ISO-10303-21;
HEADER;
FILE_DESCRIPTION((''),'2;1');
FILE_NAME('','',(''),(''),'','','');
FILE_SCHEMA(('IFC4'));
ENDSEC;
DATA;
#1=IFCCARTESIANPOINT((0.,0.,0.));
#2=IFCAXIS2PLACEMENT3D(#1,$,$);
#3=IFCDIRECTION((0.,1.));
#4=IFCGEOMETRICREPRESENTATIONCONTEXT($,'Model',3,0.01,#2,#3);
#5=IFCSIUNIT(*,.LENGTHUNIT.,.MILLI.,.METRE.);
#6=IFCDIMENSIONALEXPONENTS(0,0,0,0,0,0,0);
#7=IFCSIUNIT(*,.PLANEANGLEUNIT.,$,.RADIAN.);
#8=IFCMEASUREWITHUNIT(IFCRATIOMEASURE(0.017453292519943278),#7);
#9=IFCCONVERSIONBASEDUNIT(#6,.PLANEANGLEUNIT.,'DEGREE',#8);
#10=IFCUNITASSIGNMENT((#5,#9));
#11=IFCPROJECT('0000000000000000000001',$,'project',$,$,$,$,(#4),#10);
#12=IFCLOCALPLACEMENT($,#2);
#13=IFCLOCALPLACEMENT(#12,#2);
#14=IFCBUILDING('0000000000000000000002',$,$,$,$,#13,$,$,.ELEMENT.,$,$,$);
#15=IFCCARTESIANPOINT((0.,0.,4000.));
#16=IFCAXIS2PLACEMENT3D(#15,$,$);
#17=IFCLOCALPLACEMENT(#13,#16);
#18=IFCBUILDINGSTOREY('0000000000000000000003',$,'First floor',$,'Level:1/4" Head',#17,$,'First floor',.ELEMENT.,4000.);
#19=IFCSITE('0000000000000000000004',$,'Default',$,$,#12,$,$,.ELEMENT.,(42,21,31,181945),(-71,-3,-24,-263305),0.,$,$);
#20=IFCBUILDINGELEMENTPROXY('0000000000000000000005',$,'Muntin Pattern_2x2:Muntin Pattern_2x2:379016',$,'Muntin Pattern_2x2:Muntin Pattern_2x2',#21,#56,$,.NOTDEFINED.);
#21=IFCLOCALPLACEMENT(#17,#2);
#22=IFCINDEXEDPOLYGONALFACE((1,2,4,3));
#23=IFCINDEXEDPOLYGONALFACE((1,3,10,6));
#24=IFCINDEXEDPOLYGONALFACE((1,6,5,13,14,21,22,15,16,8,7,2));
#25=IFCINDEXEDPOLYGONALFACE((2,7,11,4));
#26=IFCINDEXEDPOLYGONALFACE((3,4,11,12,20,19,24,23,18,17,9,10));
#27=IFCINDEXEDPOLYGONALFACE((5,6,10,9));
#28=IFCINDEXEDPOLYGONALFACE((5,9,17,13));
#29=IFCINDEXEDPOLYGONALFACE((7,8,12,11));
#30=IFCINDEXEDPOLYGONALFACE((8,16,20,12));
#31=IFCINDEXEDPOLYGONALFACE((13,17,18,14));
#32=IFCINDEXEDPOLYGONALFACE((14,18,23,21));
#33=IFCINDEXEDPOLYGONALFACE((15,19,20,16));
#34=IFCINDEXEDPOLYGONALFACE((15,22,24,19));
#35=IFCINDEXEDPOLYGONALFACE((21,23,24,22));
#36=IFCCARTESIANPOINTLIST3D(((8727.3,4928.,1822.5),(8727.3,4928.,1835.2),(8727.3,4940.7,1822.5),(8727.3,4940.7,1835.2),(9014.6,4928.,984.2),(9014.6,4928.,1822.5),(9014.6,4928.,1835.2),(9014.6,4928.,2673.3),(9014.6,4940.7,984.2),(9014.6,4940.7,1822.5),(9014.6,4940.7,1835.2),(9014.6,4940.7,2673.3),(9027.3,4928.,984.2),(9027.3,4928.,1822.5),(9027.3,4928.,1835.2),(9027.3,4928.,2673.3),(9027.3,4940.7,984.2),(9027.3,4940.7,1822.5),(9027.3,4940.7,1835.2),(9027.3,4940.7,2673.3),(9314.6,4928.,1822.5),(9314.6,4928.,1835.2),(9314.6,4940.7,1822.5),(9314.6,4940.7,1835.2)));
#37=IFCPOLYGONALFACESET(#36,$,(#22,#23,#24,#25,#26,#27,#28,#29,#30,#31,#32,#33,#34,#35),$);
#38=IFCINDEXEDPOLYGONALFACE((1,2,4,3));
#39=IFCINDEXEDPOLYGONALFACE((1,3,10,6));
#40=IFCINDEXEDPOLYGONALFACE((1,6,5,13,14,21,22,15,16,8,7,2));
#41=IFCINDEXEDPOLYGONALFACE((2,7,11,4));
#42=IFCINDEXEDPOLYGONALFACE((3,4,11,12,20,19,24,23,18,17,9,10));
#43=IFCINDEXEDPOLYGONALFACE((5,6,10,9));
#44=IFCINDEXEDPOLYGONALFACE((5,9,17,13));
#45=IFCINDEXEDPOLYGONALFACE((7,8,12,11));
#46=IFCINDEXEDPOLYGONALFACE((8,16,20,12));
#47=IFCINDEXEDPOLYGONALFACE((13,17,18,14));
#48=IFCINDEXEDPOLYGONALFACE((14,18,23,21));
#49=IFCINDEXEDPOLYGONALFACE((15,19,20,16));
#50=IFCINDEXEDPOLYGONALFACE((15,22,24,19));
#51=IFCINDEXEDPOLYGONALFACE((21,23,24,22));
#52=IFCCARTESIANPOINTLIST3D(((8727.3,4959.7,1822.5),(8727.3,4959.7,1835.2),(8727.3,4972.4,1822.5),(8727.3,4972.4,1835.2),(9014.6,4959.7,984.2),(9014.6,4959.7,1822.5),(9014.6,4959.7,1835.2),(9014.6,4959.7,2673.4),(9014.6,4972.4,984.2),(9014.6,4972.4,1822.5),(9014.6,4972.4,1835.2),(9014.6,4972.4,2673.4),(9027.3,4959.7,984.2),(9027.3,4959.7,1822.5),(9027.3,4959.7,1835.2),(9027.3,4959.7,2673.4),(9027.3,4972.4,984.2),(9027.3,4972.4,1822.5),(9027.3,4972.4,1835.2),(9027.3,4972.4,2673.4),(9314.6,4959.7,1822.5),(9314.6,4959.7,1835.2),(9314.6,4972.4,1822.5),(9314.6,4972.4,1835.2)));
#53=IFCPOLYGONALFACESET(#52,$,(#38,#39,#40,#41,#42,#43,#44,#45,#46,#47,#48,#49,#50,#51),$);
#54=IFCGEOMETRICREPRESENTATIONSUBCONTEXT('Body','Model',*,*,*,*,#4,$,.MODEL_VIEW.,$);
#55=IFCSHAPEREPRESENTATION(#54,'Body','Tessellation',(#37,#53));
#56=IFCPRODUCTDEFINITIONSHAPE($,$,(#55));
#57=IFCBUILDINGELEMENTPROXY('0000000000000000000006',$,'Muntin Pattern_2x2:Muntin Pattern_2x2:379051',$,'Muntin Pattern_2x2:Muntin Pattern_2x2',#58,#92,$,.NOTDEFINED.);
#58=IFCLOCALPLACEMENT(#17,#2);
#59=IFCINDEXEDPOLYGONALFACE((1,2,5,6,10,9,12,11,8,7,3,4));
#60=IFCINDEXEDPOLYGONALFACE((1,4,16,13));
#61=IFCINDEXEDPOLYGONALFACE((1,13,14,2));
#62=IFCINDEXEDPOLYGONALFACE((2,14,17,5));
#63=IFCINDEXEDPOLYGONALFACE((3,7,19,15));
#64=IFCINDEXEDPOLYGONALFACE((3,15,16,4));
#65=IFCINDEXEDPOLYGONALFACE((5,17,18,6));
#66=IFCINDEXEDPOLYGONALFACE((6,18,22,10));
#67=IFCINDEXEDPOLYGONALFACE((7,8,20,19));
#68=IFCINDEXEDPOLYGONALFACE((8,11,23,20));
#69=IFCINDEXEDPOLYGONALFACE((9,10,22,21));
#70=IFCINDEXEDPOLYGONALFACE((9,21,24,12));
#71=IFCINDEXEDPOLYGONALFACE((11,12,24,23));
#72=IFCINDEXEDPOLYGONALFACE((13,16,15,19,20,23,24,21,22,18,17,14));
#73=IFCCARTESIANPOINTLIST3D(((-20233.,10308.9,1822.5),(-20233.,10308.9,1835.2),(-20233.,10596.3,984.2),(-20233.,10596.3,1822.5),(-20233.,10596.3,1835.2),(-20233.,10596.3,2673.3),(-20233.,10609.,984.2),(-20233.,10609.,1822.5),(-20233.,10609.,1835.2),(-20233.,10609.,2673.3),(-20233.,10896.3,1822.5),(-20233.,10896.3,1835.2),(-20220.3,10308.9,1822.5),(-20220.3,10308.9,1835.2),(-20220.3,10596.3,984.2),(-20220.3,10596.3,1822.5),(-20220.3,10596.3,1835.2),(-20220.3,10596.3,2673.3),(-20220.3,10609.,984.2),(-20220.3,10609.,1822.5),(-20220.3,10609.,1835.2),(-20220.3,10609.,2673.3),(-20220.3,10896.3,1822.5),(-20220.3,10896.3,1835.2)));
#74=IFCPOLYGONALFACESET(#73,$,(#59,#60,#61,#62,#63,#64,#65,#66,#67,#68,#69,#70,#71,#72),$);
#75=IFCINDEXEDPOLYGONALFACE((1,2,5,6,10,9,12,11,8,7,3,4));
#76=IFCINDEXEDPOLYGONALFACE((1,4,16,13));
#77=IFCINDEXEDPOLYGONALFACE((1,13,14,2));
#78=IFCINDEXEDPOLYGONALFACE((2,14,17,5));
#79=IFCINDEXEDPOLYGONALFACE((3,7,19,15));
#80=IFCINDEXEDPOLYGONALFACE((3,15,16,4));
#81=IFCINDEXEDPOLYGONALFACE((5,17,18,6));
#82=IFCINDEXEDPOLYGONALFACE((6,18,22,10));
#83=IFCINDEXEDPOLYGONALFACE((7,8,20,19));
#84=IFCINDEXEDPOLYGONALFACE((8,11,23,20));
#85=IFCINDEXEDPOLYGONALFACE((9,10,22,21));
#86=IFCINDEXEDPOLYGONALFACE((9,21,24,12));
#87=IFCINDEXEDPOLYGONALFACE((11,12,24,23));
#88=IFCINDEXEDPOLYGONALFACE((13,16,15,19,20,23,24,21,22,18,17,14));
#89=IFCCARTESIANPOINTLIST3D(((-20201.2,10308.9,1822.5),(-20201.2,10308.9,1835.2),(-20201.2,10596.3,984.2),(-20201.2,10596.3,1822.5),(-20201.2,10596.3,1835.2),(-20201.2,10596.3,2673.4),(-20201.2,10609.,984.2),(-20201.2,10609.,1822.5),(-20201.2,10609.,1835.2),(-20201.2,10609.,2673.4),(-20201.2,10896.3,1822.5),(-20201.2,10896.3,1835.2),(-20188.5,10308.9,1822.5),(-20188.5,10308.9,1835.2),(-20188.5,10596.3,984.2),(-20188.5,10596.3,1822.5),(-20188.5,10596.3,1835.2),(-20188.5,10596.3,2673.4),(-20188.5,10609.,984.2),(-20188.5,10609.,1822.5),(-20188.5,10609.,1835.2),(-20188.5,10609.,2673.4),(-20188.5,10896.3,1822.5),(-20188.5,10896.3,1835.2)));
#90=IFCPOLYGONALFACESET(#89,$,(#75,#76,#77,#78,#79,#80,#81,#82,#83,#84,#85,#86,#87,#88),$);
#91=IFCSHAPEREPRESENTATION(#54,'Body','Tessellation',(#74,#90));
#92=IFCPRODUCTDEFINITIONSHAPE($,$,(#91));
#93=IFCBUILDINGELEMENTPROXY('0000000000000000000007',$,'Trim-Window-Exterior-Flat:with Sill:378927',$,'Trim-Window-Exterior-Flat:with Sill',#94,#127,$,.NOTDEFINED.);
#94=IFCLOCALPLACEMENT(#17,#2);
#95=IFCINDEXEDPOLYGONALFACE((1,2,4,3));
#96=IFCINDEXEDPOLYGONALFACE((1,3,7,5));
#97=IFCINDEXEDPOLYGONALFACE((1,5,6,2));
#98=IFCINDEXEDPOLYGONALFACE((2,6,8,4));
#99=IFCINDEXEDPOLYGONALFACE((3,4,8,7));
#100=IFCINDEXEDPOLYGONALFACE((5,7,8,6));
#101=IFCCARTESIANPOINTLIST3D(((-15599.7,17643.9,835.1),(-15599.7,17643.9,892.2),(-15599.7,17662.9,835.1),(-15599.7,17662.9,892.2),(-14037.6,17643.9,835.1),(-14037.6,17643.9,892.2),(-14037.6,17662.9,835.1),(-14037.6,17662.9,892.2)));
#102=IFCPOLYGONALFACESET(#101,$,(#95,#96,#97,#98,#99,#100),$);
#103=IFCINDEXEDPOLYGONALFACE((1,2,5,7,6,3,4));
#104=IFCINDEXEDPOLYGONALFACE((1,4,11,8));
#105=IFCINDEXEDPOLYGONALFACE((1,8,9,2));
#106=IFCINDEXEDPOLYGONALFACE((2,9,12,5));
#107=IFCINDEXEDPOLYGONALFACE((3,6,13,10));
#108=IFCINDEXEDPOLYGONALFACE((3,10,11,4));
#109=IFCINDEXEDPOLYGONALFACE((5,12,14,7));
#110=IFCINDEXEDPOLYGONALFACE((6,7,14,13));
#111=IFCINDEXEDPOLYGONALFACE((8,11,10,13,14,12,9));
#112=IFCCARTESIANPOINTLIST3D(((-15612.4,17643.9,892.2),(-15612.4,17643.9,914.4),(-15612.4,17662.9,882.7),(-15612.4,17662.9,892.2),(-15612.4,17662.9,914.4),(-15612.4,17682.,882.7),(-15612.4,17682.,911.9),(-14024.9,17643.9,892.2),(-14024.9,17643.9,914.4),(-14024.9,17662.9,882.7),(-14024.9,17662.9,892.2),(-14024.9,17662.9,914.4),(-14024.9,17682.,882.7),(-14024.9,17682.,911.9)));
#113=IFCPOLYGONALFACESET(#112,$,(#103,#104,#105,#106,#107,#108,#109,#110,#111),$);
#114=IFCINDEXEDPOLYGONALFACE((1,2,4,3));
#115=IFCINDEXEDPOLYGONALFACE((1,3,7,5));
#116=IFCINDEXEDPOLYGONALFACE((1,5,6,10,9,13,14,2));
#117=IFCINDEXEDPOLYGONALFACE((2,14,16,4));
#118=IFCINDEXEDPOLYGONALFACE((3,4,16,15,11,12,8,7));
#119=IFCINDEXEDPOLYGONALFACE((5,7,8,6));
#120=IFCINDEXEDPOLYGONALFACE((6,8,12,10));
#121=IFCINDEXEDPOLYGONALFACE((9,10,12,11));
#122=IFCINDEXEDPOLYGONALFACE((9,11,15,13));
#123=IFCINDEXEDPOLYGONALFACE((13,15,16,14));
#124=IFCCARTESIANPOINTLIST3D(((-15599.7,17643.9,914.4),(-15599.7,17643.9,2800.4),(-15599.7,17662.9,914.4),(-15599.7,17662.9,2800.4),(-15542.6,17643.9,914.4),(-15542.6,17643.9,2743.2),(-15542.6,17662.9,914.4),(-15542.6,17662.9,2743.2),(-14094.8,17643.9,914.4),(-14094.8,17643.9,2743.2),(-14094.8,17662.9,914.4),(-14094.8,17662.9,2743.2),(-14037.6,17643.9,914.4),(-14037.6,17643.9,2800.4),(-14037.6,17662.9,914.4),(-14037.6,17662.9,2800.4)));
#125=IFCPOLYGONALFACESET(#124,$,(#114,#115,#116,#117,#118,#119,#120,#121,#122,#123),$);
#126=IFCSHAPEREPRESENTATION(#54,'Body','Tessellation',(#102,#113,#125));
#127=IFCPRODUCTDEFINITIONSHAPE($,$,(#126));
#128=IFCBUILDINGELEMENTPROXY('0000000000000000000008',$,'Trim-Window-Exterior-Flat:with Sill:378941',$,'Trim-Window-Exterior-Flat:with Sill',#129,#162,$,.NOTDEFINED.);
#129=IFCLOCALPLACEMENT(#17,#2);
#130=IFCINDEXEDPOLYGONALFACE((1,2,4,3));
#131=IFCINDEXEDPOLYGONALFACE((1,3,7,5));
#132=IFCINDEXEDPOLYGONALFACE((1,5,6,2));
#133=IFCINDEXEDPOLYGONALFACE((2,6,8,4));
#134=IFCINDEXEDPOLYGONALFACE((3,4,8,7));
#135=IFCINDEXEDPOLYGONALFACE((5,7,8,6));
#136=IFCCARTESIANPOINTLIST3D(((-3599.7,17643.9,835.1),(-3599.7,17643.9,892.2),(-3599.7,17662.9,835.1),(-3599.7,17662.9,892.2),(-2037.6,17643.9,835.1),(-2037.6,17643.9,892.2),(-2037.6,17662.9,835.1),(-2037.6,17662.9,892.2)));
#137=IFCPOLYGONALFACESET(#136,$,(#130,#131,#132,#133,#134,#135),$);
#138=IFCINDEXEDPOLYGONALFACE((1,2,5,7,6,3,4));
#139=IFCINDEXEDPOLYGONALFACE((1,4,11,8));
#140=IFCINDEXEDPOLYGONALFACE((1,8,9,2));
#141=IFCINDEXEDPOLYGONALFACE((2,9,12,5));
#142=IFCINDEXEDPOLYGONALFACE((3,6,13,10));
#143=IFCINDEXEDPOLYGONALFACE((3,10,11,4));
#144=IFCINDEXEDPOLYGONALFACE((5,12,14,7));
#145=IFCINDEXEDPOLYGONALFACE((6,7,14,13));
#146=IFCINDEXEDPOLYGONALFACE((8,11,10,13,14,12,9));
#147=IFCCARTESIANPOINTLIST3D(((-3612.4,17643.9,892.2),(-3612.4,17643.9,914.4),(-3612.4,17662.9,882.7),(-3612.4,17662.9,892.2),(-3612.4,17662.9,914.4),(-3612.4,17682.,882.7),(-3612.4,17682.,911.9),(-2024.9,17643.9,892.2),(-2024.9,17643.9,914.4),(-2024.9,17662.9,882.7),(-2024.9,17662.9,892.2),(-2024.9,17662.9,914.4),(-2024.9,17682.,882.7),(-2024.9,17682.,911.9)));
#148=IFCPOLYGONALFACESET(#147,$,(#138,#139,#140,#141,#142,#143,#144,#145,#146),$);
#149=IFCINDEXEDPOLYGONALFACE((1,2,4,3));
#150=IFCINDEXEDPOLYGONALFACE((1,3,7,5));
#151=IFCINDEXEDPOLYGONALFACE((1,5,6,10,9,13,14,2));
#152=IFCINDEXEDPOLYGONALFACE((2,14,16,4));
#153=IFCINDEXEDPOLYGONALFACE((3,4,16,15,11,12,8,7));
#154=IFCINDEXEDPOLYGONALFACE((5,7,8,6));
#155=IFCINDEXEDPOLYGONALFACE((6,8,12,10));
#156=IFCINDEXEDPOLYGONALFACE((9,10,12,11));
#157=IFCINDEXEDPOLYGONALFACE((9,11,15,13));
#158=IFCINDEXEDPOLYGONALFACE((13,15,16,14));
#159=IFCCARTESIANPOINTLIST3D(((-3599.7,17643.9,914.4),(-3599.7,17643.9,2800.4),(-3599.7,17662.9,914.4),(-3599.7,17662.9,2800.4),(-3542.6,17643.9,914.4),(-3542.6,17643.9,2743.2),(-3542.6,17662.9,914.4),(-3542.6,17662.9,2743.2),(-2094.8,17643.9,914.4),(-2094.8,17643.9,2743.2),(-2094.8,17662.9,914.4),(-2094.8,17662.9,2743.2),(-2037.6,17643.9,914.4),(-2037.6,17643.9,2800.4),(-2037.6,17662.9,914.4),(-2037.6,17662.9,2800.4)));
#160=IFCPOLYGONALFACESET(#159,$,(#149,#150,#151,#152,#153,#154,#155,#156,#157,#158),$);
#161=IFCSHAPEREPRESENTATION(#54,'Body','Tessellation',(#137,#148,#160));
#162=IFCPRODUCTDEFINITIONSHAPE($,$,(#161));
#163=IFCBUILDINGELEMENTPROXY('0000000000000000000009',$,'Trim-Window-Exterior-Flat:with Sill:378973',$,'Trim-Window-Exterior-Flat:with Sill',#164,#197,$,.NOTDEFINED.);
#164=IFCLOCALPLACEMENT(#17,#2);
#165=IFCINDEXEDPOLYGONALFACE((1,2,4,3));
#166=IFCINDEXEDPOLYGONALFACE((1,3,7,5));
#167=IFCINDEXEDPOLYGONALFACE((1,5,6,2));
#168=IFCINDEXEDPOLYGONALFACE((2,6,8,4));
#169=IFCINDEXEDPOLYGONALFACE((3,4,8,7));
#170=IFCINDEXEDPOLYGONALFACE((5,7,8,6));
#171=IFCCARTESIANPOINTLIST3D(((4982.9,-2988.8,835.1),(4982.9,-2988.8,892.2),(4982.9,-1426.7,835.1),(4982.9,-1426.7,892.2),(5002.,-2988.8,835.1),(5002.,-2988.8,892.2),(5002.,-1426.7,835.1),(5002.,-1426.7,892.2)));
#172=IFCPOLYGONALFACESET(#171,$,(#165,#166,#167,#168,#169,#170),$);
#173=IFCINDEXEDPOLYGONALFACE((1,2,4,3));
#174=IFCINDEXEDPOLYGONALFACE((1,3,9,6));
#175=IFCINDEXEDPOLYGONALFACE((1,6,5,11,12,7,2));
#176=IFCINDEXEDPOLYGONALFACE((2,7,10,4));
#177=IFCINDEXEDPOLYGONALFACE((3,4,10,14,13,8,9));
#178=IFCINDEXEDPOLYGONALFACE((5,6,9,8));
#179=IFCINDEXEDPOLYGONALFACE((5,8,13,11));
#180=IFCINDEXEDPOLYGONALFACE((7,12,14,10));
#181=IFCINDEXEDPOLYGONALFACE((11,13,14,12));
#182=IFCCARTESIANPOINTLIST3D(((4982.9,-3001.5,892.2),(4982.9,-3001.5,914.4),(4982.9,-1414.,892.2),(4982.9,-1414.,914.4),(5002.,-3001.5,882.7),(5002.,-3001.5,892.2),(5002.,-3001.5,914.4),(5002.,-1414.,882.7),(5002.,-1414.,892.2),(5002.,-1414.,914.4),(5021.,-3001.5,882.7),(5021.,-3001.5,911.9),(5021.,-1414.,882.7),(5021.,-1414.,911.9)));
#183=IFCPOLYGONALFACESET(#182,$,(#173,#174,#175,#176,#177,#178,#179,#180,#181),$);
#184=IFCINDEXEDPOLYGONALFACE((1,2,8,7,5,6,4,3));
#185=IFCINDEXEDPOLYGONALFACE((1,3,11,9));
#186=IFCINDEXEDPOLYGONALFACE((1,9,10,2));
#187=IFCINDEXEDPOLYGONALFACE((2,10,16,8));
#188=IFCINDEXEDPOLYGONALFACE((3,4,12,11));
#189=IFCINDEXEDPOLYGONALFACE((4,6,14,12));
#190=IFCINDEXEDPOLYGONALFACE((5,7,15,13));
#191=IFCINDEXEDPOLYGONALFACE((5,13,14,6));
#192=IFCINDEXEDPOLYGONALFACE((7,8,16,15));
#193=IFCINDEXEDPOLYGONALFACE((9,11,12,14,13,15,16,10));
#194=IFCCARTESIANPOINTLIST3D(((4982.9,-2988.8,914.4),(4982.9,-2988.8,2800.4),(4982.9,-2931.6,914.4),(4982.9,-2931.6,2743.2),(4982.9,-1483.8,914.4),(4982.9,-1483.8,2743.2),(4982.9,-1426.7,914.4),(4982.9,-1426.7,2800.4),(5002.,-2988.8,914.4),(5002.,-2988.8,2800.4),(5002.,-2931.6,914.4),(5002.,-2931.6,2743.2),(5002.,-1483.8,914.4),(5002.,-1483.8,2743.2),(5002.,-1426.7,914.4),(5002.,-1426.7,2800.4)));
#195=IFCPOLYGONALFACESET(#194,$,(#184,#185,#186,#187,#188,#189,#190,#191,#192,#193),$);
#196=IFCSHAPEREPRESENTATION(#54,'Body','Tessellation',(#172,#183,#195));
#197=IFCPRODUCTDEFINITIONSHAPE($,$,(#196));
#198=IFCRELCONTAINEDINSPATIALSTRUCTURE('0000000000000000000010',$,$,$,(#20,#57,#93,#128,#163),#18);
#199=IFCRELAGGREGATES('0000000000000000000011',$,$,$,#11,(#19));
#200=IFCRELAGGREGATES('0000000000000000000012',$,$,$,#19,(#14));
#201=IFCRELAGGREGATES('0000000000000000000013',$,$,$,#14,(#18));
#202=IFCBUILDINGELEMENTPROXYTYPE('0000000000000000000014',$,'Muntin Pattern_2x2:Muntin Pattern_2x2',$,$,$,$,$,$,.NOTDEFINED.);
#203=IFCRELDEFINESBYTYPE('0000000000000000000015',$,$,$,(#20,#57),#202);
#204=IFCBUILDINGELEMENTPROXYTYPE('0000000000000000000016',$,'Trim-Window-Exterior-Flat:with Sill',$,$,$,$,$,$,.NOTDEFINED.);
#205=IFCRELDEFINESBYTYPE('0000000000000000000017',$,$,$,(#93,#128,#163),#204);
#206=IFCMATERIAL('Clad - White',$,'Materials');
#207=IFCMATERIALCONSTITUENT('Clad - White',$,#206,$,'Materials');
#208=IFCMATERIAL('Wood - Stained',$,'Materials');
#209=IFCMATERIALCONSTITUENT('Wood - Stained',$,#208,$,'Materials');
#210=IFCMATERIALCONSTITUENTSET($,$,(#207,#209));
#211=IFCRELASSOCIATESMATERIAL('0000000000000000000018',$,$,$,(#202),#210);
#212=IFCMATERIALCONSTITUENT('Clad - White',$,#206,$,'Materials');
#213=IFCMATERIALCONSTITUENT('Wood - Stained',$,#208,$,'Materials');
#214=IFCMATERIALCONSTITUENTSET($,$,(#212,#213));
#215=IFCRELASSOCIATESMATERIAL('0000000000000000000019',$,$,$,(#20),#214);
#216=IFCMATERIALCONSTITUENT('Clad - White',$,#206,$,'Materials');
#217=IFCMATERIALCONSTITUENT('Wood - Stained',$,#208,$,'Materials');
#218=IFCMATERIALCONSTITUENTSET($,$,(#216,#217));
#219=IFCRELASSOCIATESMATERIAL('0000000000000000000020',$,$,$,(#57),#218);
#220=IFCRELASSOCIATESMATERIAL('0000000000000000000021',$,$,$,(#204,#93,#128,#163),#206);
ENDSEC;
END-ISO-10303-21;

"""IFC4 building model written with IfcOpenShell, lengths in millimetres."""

from ifc_helpers import new_model, entity, si_unit, converted_unit, direction, frame, origin, place, context, subcontext, project, spatial, indexed_curve, outline, extrude, source, transform, mapped, material, constituent, constituent_set, type_object, type_shapes, element, save


model = new_model("IFC4")

# Units and contexts
model_context = context("Model", 3, precision=0.01, world=origin(), true_north=direction((0.0, 1.0)))
body_context = subcontext(model_context, "Body", "Model", "MODEL_VIEW")
ifc_project = project(units=[si_unit("LENGTHUNIT", "METRE", prefix="MILLI"), converted_unit("PLANEANGLEUNIT", "DEGREE", entity("IfcRatioMeasure", 0.017453292519943278), si_unit("PLANEANGLEUNIT", "RADIAN"), dimensions=[0, 0, 0, 0, 0, 0, 0])], contexts=[model_context])

# Site, building, storey
site_placement = place(None, origin())
site = spatial("IfcSite", under=ifc_project, at=site_placement, Name="Default", CompositionType="ELEMENT", RefLatitude=(42, 21, 31, 181945), RefLongitude=(-71, -3, -24, -263305), RefElevation=0.0)
building_placement = place(site_placement, origin())
building = spatial("IfcBuilding", under=site, at=building_placement, CompositionType="ELEMENT")
storey_placement = place(building_placement, frame((0.0, 0.0, 4000.0)))
storey = spatial("IfcBuildingStorey", under=building, at=storey_placement, Name="First floor", ObjectType="Level:1/4\" Head", LongName="First floor", CompositionType="ELEMENT", Elevation=4000.0)

# Building element proxies
ifc_material_1 = material(Name="Clad - White", Category="Materials")
ifc_material_2 = material(Name="Wood - Stained", Category="Materials")
ifc_constituent_1 = constituent(ifc_material_1, Name="Clad - White", Category="Materials")
ifc_constituent_2 = constituent(ifc_material_2, Name="Wood - Stained", Category="Materials")
ifc_constituent_set_1 = constituent_set(constituents=[ifc_constituent_1, ifc_constituent_2])
building_element_proxy_type_1 = type_object("IfcBuildingElementProxyType", Name="Muntin Pattern_2x2:Muntin Pattern_2x2", PredefinedType="NOTDEFINED", material=ifc_constituent_set_1)
shared_shape_1 = source(origin(), body_context, "Body", "SweptSolid", [
    extrude(outline(indexed_curve([(6.4, -6.4), (844.5, -6.4), (844.5, 6.3), (6.4, 6.3), (6.4, 293.7), (-6.3, 293.7), (-6.3, 6.3), (-844.6, 6.3), (-844.6, -6.4), (-6.3, -6.4), (-6.3, -293.7), (6.4, -293.7), (6.4, -6.4)], self_intersect=False)), frame((0.0, -22.2, 844.5), z_axis=(0.0, 1.0, 0.0), x_axis=(0.0, 0.0, 1.0)), (0.0, 0.0, 1.0), 12.7),
    extrude(outline(indexed_curve([(6.4, -6.4), (844.6, -6.4), (844.6, 6.3), (6.4, 6.3), (6.4, 293.7), (-6.3, 293.7), (-6.3, 6.3), (-844.6, 6.3), (-844.6, -6.4), (-6.3, -6.4), (-6.3, -293.7), (6.4, -293.7), (6.4, -6.4)], self_intersect=False)), frame((0.0, 9.5, 844.6), z_axis=(0.0, 1.0, 0.0), x_axis=(0.0, 0.0, 1.0)), (0.0, 0.0, 1.0), 12.7),
])
type_shapes(building_element_proxy_type_1, [shared_shape_1])
ifc_constituent_3 = constituent(ifc_material_1, Name="Clad - White", Category="Materials")
ifc_constituent_4 = constituent(ifc_material_2, Name="Wood - Stained", Category="Materials")
ifc_constituent_set_2 = constituent_set(constituents=[ifc_constituent_3, ifc_constituent_4])
proxy_1_placement = place(storey_placement, frame((9020.9, 4950.2, 984.3)))
element("IfcBuildingElementProxy", 1, at=proxy_1_placement, inside=storey, type_object=building_element_proxy_type_1, material=ifc_constituent_set_2, Name="Muntin Pattern_2x2:Muntin Pattern_2x2:379016", ObjectType="Muntin Pattern_2x2:Muntin Pattern_2x2", PredefinedType="NOTDEFINED", context=body_context, shape_type="MappedRepresentation", body=[
    mapped(shared_shape_1, transform((0.0, 0.0, 0.0), scale=1.0)),
])
ifc_constituent_5 = constituent(ifc_material_1, Name="Clad - White", Category="Materials")
ifc_constituent_6 = constituent(ifc_material_2, Name="Wood - Stained", Category="Materials")
ifc_constituent_set_3 = constituent_set(constituents=[ifc_constituent_5, ifc_constituent_6])
proxy_2_placement = place(storey_placement, frame((-20210.8, 10602.6, 984.3), z_axis=(0.0, 0.0, 1.0), x_axis=(0.0, -1.0, 0.0)))
element("IfcBuildingElementProxy", 2, at=proxy_2_placement, inside=storey, type_object=building_element_proxy_type_1, material=ifc_constituent_set_3, Name="Muntin Pattern_2x2:Muntin Pattern_2x2:379051", ObjectType="Muntin Pattern_2x2:Muntin Pattern_2x2", PredefinedType="NOTDEFINED", context=body_context, shape_type="MappedRepresentation", body=[
    mapped(shared_shape_1, transform((0.0, 0.0, 0.0), scale=1.0)),
])
building_element_proxy_type_2 = type_object("IfcBuildingElementProxyType", Name="Trim-Window-Exterior-Flat:with Sill", PredefinedType="NOTDEFINED", material=ifc_material_1)
shared_shape_2 = source(origin(), body_context, "Body", "SweptSolid", [
    extrude(outline(indexed_curve([(-781.0, -28.6), (781.0, -28.6), (781.0, 28.6), (-781.0, 28.6), (-781.0, -28.6)], self_intersect=False)), frame((0.0, -1879.6, 0.0), z_axis=(0.0, 0.0, 1.0), x_axis=(-1.0, 0.0, 0.0)), (0.0, 0.0, 1.0), 19.0),
    extrude(outline(indexed_curve([(-19.0, -16.0), (0.0, -16.0), (0.0, -6.4), (19.0, -6.4), (19.0, 15.8), (0.0, 15.8), (-19.0, 13.3), (-19.0, -16.0)], self_intersect=False)), frame((-793.7, -1844.6, 19.0), z_axis=(1.0, 0.0, 0.0), x_axis=(0.0, 0.0, -1.0)), (0.0, 0.0, 1.0), 1587.5),
    extrude(outline(indexed_curve([(-957.3, -781.0), (928.7, -781.0), (928.7, -723.9), (-900.1, -723.9), (-900.1, 723.9), (928.7, 723.9), (928.7, 781.0), (-957.3, 781.0), (-957.3, -781.0)], self_intersect=False)), frame((0.0, -900.1, 0.0), z_axis=(0.0, 0.0, 1.0), x_axis=(0.0, -1.0, 0.0)), (0.0, 0.0, 1.0), 19.0),
])
type_shapes(building_element_proxy_type_2, [shared_shape_2])
for number, where, z_axis, x_axis, name in (
    (3, (-14818.7, 17643.9, 2743.2), (0.0, 1.0, 0.0), (-1.0, 0.0, 0.0), "Trim-Window-Exterior-Flat:with Sill:378927"),
    (4, (-2818.7, 17643.9, 2743.2), (0.0, 1.0, 0.0), (-1.0, 0.0, 0.0), "Trim-Window-Exterior-Flat:with Sill:378941"),
    (5, (4982.9, -2207.7, 2743.2), (1.0, 0.0, 0.0), (0.0, 1.0, 0.0), "Trim-Window-Exterior-Flat:with Sill:378973"),
):
    element("IfcBuildingElementProxy", number, at=place(storey_placement, frame(where, z_axis=z_axis, x_axis=x_axis)), inside=storey, type_object=building_element_proxy_type_2, material=ifc_material_1, Name=name, ObjectType="Trim-Window-Exterior-Flat:with Sill", PredefinedType="NOTDEFINED", context=body_context, shape_type="MappedRepresentation", body=[
        mapped(shared_shape_2, transform((0.0, 0.0, 0.0), scale=1.0)),
    ])

save(model, "model.ifc")
